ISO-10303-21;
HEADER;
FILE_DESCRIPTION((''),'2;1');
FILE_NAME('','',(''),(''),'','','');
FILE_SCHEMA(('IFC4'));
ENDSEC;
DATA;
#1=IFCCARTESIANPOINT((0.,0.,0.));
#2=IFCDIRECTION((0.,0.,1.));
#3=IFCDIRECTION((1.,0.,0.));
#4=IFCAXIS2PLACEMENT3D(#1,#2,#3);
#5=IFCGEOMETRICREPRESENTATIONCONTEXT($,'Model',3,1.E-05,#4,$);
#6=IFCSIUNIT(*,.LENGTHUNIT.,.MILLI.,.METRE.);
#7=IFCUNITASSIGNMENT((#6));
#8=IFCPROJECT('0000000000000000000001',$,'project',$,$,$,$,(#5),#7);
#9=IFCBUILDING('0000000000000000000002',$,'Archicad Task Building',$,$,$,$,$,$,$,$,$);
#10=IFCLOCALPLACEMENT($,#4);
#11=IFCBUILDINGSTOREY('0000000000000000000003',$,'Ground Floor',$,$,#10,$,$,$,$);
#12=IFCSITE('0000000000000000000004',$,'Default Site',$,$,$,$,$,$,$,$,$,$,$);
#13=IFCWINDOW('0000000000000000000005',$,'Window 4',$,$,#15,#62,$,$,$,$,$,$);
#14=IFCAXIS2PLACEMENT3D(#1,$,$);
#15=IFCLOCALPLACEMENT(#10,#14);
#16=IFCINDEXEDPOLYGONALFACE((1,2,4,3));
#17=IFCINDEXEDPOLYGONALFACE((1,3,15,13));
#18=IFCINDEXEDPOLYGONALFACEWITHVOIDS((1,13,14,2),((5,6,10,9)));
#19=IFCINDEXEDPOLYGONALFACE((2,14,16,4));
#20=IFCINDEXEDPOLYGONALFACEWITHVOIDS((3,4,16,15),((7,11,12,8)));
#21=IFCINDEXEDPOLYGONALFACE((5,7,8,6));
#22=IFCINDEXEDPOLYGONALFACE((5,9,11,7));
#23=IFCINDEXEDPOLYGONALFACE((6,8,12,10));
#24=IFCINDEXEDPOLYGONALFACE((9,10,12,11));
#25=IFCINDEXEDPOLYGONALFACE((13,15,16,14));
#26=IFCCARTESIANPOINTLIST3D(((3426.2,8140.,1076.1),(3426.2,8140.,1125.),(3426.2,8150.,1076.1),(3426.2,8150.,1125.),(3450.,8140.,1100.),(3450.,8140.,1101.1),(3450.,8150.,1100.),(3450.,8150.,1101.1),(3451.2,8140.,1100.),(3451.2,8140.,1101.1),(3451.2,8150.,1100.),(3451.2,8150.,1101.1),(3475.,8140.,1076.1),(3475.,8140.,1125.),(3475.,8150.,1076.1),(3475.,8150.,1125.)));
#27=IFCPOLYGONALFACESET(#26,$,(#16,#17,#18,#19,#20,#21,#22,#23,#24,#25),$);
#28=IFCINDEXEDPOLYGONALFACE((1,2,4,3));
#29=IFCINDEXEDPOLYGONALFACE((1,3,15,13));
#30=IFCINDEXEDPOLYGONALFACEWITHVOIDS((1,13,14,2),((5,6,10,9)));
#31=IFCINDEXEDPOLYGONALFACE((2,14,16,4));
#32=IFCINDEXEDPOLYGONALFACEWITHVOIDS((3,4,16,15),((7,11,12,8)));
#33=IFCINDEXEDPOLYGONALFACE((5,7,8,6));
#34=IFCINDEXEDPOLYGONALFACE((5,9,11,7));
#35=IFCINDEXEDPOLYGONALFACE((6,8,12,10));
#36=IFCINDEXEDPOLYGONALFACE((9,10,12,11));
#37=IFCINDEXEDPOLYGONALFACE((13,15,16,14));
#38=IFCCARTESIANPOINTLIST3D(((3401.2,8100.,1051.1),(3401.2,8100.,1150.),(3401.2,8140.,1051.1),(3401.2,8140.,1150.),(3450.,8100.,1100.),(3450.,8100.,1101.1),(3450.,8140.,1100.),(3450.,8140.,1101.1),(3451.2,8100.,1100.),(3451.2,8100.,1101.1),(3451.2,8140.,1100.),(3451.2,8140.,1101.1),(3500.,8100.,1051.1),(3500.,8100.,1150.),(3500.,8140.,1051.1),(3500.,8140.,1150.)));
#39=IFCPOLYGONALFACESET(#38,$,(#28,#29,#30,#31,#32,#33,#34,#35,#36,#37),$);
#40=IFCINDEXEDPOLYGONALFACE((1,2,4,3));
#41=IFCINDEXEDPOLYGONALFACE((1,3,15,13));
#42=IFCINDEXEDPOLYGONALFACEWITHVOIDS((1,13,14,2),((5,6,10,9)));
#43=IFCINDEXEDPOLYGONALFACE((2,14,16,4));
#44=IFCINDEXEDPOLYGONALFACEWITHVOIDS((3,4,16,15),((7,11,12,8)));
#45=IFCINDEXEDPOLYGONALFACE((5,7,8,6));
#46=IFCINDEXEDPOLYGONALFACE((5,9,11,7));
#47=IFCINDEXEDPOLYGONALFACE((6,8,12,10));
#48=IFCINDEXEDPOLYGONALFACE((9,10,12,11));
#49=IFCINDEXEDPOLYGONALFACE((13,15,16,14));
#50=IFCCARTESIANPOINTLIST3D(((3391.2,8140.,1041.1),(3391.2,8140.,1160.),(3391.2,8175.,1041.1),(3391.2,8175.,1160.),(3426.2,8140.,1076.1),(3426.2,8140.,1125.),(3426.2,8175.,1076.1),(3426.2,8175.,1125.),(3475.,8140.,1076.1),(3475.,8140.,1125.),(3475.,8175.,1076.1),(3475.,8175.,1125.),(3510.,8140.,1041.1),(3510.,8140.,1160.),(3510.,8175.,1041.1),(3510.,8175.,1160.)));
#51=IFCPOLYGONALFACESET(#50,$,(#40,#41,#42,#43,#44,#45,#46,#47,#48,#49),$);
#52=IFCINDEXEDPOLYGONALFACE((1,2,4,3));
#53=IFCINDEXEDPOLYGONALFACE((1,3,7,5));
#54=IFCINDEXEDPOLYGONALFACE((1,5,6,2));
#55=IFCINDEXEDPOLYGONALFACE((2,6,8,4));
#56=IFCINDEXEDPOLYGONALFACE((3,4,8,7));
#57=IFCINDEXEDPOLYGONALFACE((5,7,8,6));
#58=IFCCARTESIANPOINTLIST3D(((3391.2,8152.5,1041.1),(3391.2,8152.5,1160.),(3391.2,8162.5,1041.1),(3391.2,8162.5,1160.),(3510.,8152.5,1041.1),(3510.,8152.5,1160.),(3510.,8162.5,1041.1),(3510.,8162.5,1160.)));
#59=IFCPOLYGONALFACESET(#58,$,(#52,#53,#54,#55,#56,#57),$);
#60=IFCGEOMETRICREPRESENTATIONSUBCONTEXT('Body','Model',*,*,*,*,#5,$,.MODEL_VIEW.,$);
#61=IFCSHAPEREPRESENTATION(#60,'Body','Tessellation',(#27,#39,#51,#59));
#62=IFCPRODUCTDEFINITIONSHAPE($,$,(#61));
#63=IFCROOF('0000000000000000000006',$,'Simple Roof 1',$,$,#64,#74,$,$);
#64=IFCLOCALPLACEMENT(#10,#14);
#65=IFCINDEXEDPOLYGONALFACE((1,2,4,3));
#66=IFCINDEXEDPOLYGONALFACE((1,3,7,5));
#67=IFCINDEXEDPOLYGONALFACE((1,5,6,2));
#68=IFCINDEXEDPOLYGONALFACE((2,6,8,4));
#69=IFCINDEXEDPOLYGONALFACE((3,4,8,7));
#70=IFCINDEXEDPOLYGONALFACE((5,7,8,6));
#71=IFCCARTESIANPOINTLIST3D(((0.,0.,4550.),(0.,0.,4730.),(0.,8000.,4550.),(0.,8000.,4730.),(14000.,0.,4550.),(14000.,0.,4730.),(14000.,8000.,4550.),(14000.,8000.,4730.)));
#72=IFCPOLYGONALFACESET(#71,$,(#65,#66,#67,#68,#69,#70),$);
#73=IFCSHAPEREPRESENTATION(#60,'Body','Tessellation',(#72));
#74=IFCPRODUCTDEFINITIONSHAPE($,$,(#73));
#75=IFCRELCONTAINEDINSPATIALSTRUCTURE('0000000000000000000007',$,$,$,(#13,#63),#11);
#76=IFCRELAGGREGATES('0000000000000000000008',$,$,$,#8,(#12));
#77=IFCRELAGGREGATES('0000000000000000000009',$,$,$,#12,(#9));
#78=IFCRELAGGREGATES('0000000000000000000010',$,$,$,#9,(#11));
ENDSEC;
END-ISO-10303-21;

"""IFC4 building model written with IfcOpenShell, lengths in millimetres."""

from ifc_helpers import new_model, si_unit, frame, origin_with_axes, place, context, subcontext, project, spatial, line, indexed_curve, outline, extrude, element, save


model = new_model("IFC4")

# Units and contexts
model_context = context("Model", 3, precision=1e-05, world=origin_with_axes())
body_context = subcontext(model_context, "Body", "Model", "MODEL_VIEW")
ifc_project = project(units=[si_unit("LENGTHUNIT", "METRE", prefix="MILLI")], contexts=[model_context])

# Site, building, storey
site = spatial("IfcSite", under=ifc_project, Name="Default Site")
building = spatial("IfcBuilding", under=site, Name="Archicad Task Building")
storey_placement = place(None, origin_with_axes())
storey = spatial("IfcBuildingStorey", under=building, at=storey_placement, Name="Ground Floor")

# Window
for number, where, z_axis, x_axis, name in (
    (1, (3450.0, 8050.0, 1100.0), (0.0, 0.0, 1.0), (1.0, 0.0, 0.0), "Window 4"),
):
    element("IfcWindow", number, at=place(storey_placement, frame(where, z_axis=z_axis, x_axis=x_axis)), inside=storey, Name=name, context=body_context, shape_type="SweptSolid", body=[
        extrude(outline(indexed_curve([(0.0, 0.0), (1.2, 0.0), (1.2, 1.1), (0.0, 1.1)], segments=[line(1, 2, 3, 4, 1)]), holes=[indexed_curve([(25.0, 25.0), (-23.8, 25.0), (-23.8, -23.9), (25.0, -23.9)], segments=[line(1, 2, 3, 4, 1)])]), frame((0.0, 90.0, 0.0), z_axis=(0.0, -1.0, 0.0), x_axis=(1.0, 0.0, 0.0)), (0.0, 0.0, -1.0), 10.0),
        extrude(outline(indexed_curve([(0.0, 0.0), (1.2, 0.0), (1.2, 1.1), (0.0, 1.1)], segments=[line(1, 2, 3, 4, 1)]), holes=[indexed_curve([(50.0, 50.0), (-48.8, 50.0), (-48.8, -48.9), (50.0, -48.9)], segments=[line(1, 2, 3, 4, 1)])]), frame((0.0, 50.0, 0.0), z_axis=(0.0, -1.0, 0.0), x_axis=(1.0, 0.0, 0.0)), (0.0, 0.0, -1.0), 40.0),
        extrude(outline(indexed_curve([(0.0, 0.0), (-48.8, 0.0), (-48.8, -48.9), (0.0, -48.9)], segments=[line(1, 2, 3, 4, 1)]), holes=[indexed_curve([(35.0, 35.0), (-83.8, 35.0), (-83.8, -83.9), (35.0, -83.9)], segments=[line(1, 2, 3, 4, 1)])]), frame((25.0, 90.0, 25.0), z_axis=(0.0, -1.0, 0.0), x_axis=(1.0, 0.0, 0.0)), (0.0, 0.0, -1.0), 35.0),
        extrude(outline(indexed_curve([(35.0, 35.0), (-83.8, 35.0), (-83.8, -83.9), (35.0, -83.9)], segments=[line(1, 2, 3, 4, 1)])), frame((25.0, 102.5, 25.0), z_axis=(0.0, -1.0, 0.0), x_axis=(1.0, 0.0, 0.0)), (0.0, 0.0, -1.0), 10.0),
    ])

# Roof
roof_placement = place(storey_placement, frame((0.0, 0.0, 4550.0), z_axis=(0.0, 0.0, 1.0), x_axis=(1.0, 0.0, 0.0)))
element("IfcRoof", 2, at=roof_placement, inside=storey, Name="Simple Roof 1", context=body_context, shape_type="SweptSolid", body=[
    extrude(outline(indexed_curve([(0.0, 0.0), (14000.0, 0.0), (14000.0, 8000.0), (0.0, 8000.0), (0.0, 0.0)])), None, (0.0, 0.0, 1.0), 180.0),
])

save(model, "model.ifc")
